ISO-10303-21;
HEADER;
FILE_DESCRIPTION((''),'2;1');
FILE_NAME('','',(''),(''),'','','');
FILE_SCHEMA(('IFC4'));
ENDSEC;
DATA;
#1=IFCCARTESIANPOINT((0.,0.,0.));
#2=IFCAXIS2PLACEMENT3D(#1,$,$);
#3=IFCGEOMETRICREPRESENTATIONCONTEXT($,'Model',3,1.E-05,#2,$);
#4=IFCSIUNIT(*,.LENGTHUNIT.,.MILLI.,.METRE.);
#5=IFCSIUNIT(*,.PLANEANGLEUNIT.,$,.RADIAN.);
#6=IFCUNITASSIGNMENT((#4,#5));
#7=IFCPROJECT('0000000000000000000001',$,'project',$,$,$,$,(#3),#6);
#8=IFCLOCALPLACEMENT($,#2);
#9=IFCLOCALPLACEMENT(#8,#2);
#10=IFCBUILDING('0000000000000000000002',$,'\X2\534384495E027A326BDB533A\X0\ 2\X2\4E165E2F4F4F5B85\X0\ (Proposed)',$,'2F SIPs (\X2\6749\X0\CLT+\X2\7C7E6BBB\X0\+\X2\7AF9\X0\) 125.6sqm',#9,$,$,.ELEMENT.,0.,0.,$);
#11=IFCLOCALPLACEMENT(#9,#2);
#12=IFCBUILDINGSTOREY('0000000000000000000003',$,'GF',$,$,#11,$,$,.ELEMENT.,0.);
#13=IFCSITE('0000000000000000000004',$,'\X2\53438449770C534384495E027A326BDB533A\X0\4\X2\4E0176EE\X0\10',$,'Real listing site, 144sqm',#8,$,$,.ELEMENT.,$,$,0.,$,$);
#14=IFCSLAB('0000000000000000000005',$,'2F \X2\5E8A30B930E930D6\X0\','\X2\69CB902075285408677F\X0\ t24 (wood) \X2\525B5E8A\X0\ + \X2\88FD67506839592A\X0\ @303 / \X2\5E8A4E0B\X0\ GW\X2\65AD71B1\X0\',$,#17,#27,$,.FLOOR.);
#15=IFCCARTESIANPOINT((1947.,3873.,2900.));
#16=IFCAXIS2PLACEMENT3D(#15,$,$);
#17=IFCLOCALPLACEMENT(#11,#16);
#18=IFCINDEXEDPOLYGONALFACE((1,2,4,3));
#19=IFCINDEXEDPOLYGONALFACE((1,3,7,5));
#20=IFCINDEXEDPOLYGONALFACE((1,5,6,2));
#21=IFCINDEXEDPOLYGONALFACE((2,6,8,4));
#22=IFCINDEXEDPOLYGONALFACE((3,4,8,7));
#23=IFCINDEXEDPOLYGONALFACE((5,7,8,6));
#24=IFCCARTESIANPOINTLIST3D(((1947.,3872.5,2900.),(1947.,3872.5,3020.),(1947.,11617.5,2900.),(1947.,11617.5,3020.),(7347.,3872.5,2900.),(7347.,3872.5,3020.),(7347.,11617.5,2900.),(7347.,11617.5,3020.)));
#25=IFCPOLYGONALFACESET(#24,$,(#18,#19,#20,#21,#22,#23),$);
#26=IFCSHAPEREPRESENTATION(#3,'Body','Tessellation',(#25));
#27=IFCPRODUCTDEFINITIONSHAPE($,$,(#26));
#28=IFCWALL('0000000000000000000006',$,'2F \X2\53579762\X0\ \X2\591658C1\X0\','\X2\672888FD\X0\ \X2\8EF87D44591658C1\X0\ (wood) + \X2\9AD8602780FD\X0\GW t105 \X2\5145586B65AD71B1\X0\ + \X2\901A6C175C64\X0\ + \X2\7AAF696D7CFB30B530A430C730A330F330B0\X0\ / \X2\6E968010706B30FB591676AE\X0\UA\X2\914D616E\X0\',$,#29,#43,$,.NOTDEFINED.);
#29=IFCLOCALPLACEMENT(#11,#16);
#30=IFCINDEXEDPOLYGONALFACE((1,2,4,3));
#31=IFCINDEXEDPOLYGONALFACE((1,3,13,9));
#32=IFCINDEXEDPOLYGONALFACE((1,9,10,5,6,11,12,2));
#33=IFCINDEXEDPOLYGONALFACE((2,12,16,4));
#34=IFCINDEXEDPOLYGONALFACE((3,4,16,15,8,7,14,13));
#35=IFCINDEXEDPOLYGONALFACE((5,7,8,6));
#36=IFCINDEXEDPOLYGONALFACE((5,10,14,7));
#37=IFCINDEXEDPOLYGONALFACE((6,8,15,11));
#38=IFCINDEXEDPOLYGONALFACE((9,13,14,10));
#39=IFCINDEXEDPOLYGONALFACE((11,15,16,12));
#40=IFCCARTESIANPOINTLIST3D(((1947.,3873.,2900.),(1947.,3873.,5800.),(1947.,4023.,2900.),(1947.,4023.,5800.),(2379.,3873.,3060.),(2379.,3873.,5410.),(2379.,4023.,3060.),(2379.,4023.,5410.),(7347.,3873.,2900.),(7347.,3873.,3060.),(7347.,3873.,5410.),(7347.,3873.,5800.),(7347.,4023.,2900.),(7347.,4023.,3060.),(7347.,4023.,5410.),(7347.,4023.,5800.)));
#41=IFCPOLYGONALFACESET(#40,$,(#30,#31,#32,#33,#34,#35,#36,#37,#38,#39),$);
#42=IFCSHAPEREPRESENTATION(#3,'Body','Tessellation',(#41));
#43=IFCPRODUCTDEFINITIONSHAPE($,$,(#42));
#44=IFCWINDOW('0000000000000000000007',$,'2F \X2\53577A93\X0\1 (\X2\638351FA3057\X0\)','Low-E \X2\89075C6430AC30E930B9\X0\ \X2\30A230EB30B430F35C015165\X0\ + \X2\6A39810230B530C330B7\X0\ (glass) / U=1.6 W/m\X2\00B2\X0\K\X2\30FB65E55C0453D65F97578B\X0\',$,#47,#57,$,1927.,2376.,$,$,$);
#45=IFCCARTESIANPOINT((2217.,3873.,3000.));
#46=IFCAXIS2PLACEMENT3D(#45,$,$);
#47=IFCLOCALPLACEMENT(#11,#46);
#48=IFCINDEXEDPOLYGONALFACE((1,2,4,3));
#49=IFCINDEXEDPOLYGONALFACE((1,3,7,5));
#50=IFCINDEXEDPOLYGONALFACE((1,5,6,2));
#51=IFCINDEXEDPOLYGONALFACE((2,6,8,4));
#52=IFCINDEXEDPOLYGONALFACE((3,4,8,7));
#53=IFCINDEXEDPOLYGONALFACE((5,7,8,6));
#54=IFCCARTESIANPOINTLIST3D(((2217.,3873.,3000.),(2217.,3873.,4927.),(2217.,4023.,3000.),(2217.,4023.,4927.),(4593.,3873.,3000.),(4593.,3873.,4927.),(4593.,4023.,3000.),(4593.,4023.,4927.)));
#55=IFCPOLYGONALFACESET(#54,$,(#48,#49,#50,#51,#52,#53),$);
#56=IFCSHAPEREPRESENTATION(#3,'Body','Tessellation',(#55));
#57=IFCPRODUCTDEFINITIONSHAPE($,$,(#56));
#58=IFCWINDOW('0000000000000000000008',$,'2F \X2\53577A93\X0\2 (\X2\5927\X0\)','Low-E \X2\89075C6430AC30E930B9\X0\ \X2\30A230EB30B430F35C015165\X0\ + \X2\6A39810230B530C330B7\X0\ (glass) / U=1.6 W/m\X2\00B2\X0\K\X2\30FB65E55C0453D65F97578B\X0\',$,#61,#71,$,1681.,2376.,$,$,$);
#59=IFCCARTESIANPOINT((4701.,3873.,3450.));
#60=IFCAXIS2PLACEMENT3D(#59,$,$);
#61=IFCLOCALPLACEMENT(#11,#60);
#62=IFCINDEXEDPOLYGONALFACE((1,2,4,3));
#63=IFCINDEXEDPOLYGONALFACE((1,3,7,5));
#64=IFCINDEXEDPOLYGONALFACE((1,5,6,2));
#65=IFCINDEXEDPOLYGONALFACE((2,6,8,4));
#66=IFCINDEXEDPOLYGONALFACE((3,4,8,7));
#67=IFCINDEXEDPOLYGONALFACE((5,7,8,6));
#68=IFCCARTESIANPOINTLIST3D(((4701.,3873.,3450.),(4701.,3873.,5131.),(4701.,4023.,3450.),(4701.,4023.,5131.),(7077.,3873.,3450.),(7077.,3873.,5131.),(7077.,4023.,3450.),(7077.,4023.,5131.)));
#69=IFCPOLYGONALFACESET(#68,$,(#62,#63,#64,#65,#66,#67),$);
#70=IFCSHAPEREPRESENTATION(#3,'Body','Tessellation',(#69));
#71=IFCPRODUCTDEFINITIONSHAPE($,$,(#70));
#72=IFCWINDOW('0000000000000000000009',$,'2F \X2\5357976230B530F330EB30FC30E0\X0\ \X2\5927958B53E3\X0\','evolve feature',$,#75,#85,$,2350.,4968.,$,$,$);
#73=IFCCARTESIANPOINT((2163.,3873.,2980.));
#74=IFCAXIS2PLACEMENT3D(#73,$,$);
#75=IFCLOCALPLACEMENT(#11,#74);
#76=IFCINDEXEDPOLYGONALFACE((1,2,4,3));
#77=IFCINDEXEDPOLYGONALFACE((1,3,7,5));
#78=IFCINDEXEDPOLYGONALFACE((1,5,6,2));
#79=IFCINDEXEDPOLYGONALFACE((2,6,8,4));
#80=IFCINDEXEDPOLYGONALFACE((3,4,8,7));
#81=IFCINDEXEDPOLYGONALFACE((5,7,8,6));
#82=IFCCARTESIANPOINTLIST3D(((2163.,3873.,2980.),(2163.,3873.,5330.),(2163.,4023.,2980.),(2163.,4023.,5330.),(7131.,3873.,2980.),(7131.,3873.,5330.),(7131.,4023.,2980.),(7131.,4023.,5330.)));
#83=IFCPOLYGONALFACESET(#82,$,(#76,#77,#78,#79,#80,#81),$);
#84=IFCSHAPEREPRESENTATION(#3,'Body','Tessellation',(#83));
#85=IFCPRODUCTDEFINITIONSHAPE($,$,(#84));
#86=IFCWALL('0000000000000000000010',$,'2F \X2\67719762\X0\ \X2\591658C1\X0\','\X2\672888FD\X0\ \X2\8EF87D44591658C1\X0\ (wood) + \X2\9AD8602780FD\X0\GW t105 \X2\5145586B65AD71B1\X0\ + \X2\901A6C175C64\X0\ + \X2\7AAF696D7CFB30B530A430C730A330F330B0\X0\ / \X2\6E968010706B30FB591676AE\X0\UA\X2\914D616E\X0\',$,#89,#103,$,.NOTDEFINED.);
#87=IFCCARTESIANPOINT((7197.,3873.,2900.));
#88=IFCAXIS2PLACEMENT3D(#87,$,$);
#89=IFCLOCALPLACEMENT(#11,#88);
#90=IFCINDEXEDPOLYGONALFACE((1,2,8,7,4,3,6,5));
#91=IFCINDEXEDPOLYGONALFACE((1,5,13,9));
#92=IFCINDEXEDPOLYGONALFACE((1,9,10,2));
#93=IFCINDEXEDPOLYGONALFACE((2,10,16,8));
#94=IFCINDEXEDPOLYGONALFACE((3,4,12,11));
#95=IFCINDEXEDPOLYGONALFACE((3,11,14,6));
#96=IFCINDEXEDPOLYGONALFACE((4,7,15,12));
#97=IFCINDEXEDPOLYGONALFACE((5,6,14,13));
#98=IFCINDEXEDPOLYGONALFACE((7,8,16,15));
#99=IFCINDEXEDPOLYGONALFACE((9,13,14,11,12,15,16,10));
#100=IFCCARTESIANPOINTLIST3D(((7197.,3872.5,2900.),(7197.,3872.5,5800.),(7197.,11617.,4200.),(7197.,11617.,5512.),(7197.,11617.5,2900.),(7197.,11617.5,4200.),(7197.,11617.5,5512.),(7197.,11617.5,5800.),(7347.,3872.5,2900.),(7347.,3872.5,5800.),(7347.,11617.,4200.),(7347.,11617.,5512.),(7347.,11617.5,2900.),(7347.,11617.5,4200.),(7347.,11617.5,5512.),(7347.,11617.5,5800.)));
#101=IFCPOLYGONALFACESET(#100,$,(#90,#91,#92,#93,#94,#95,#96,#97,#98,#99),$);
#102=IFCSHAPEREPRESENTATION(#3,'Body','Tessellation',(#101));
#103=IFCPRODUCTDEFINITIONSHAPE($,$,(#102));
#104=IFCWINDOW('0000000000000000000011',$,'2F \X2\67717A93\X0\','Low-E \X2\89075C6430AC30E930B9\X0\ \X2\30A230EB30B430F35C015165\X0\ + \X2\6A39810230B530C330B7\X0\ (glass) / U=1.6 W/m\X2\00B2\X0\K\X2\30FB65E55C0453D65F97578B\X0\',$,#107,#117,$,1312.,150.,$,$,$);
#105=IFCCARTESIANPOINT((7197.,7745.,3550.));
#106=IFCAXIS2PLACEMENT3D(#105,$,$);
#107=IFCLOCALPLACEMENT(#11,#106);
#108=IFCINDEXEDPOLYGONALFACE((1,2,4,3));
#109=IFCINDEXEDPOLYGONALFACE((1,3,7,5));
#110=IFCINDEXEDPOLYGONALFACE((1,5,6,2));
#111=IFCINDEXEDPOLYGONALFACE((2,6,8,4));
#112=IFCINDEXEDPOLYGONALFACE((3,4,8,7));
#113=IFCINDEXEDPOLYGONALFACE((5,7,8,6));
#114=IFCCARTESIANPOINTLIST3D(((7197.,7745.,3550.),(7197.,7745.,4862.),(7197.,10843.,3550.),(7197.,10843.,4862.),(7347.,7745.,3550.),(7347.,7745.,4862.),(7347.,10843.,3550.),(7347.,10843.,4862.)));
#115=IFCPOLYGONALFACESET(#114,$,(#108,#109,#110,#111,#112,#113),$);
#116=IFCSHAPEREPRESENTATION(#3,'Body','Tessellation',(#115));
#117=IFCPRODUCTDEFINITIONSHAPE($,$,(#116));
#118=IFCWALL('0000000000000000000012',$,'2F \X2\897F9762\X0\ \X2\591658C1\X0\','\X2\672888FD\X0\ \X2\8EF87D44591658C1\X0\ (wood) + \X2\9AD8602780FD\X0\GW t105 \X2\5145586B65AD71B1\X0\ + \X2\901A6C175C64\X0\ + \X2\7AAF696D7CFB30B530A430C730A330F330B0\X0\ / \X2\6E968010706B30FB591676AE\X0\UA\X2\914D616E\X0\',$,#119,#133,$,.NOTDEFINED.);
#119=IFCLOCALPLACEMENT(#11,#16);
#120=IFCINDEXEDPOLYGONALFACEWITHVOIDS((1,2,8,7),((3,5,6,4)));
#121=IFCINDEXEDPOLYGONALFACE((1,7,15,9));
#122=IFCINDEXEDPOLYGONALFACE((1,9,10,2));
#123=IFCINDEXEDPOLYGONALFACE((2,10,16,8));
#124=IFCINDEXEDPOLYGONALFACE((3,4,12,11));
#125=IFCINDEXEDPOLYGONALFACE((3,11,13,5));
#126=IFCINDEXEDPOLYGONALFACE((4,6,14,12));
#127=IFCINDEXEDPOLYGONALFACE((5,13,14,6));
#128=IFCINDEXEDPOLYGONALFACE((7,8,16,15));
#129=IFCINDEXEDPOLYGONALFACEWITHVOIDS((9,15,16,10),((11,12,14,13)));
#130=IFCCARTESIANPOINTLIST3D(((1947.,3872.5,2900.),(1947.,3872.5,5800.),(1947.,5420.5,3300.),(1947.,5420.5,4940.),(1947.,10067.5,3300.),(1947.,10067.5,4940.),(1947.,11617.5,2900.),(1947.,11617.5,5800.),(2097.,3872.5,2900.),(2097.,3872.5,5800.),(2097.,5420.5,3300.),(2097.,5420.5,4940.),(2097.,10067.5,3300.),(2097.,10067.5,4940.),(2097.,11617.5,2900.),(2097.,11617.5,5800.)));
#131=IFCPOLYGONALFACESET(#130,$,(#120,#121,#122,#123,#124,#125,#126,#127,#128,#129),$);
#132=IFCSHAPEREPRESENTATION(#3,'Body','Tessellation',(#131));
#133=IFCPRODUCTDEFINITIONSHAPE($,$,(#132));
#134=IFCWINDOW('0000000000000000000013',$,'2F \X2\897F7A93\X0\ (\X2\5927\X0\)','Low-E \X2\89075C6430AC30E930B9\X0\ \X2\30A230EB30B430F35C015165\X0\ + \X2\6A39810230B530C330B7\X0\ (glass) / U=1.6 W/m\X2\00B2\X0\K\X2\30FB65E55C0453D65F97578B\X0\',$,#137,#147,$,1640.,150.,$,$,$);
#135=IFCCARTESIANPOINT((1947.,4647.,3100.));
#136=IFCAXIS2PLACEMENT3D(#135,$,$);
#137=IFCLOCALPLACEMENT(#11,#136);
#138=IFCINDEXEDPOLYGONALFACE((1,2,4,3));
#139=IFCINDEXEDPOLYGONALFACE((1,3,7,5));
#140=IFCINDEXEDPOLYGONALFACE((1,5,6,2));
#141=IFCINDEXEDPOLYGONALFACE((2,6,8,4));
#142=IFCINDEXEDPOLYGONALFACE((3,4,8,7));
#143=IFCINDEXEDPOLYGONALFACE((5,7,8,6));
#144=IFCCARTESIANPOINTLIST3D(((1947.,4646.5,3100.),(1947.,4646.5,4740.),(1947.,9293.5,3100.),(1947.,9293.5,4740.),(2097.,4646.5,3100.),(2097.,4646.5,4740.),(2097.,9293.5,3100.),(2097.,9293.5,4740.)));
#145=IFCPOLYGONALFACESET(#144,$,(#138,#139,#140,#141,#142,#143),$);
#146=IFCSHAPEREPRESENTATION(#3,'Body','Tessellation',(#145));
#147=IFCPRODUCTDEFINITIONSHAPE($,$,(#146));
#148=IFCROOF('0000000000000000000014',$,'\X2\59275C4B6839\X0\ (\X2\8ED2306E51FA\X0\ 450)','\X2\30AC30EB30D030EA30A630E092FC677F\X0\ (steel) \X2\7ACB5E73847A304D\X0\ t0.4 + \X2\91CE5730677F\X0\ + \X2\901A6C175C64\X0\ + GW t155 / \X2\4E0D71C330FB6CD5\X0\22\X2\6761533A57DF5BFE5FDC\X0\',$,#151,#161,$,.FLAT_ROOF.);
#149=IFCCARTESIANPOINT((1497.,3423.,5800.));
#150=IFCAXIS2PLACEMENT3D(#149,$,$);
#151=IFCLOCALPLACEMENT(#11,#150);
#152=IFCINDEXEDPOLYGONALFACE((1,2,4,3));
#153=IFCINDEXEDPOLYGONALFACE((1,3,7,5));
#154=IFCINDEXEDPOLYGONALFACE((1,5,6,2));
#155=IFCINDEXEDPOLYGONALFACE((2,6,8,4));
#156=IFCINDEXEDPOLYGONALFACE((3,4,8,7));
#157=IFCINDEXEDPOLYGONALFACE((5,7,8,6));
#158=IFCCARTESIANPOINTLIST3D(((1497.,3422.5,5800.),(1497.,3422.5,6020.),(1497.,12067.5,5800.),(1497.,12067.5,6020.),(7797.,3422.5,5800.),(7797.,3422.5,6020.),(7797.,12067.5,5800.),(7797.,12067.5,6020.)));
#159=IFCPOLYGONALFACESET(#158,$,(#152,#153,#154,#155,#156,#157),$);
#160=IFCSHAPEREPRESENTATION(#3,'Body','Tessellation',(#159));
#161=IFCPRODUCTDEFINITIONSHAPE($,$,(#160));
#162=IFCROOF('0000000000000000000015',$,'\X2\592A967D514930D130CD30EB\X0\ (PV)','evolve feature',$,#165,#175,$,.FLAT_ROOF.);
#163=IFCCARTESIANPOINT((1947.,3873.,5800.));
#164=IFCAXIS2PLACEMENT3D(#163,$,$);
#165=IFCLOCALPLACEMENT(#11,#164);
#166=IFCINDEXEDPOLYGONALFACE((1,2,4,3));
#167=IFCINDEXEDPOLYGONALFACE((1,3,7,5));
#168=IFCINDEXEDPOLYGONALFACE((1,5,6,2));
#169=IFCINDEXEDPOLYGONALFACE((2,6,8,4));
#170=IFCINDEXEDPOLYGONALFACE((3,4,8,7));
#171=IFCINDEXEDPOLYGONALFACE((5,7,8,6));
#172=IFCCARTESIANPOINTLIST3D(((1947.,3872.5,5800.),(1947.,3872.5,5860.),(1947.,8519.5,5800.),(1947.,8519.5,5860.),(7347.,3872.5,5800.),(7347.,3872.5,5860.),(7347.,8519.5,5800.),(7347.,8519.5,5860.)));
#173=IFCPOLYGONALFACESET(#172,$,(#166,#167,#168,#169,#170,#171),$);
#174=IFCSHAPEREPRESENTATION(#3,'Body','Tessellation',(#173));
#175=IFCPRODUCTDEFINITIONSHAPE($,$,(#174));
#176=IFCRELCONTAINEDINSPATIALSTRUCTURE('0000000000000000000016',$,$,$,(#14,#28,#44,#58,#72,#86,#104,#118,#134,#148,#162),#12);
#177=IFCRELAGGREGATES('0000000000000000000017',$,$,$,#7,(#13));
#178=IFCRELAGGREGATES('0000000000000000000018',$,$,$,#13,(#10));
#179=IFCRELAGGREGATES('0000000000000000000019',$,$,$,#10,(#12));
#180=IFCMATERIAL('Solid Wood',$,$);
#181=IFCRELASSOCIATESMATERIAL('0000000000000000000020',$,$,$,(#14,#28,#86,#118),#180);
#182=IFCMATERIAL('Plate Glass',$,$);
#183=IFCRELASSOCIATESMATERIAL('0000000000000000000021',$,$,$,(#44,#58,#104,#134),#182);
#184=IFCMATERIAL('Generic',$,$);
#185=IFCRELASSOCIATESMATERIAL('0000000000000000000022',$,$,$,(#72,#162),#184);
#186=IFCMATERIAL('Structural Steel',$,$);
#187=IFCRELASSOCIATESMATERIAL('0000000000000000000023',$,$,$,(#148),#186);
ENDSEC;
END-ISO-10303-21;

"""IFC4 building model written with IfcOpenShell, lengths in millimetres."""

from ifc_helpers import new_model, si_unit, frame, frame_2d, origin, place, context, project, spatial, rectangle, extrude, material, element, fill, save


model = new_model("IFC4")

# Units and contexts
model_context = context("Model", 3, precision=1e-05, world=origin())
ifc_project = project(units=[si_unit("LENGTHUNIT", "METRE", prefix="MILLI"), si_unit("PLANEANGLEUNIT", "RADIAN")], contexts=[model_context])

# Site, building, storey
site_placement = place(None, origin())
site = spatial("IfcSite", under=ifc_project, at=site_placement, Name="千葉県千葉市稲毛区4丁目10", ObjectType="Real listing site, 144sqm", CompositionType="ELEMENT", RefElevation=0.0)
building_placement = place(site_placement, origin())
building = spatial("IfcBuilding", under=site, at=building_placement, Name="千葉市稲毛区 2世帯住宅 (Proposed)", ObjectType="2F SIPs (杉CLT+籾殻+竹) 125.6sqm", CompositionType="ELEMENT", ElevationOfRefHeight=0.0, ElevationOfTerrain=0.0)
storey_placement = place(building_placement, origin())
storey = spatial("IfcBuildingStorey", under=building, at=storey_placement, Name="GF", CompositionType="ELEMENT", Elevation=0.0)

# Slab
ifc_material_1 = material(Name="Solid Wood")
slab_placement = place(storey_placement, frame((1947.0, 3873.0, 2900.0)))
element("IfcSlab", 1, at=slab_placement, inside=storey, material=ifc_material_1, Name="2F 床スラブ", Description="構造用合板 t24 (wood) 剛床 + 製材根太 @303 / 床下 GW断熱", PredefinedType="FLOOR", context=model_context, shape_type="SweptSolid", body=[
    extrude(rectangle(XDim=5400.0, YDim=7745.0, at=frame_2d((2700.0, 3872.0))), frame((1947.0, 3873.0, 2900.0)), (0.0, 0.0, 1.0), 120.0),
])

# Wall, openings, windows
wall_1_placement = place(storey_placement, frame((1947.0, 3873.0, 2900.0)))
wall_1 = element("IfcWall", 2, at=wall_1_placement, inside=storey, material=ifc_material_1, Name="2F 南面 外壁", Description="木製 軸組外壁 (wood) + 高性能GW t105 充填断熱 + 通気層 + 窯業系サイディング / 準耐火・外皮UA配慮", PredefinedType="NOTDEFINED", context=model_context, shape_type="SweptSolid", body=[
    extrude(rectangle(XDim=5400.0, YDim=150.0, at=frame_2d((2700.0, 75.0))), frame((1947.0, 3873.0, 2900.0)), (0.0, 0.0, 1.0), 2900.0),
])
opening_1_placement = place(storey_placement, frame((2217.0, 3873.0, 3000.0)))
opening_1 = element("IfcOpeningElement", 3, at=opening_1_placement, cuts=wall_1, PredefinedType="NOTDEFINED", context=model_context, shape_type="SweptSolid", body=[
    extrude(rectangle(XDim=2376.0, YDim=150.0, at=frame_2d((1188.0, 75.0))), frame((2217.0, 3873.0, 3000.0)), (0.0, 0.0, 1.0), 1927.0),
])
opening_2_placement = place(storey_placement, frame((4701.0, 3873.0, 3450.0)))
opening_2 = element("IfcOpeningElement", 4, at=opening_2_placement, cuts=wall_1, PredefinedType="NOTDEFINED", context=model_context, shape_type="SweptSolid", body=[
    extrude(rectangle(XDim=2376.0, YDim=150.0, at=frame_2d((1188.0, 75.0))), frame((4701.0, 3873.0, 3450.0)), (0.0, 0.0, 1.0), 1681.0),
])
opening_3_placement = place(storey_placement, frame((2163.0, 3873.0, 2980.0)))
opening_3 = element("IfcOpeningElement", 5, at=opening_3_placement, cuts=wall_1, PredefinedType="NOTDEFINED", context=model_context, shape_type="SweptSolid", body=[
    extrude(rectangle(XDim=4968.0, YDim=150.0, at=frame_2d((2484.0, 75.0))), frame((2163.0, 3873.0, 2980.0)), (0.0, 0.0, 1.0), 2350.0),
])
ifc_material_2 = material(Name="Plate Glass")
window_1_placement = place(storey_placement, frame((2217.0, 3873.0, 3000.0)))
window_1 = element("IfcWindow", 6, at=window_1_placement, inside=storey, material=ifc_material_2, Name="2F 南窓1 (掃出し)", Description="Low-E 複層ガラス アルゴン封入 + 樹脂サッシ (glass) / U=1.6 W/m²K・日射取得型", OverallHeight=1927.0, OverallWidth=2376.0, context=model_context, shape_type="SweptSolid", body=[
    extrude(rectangle(XDim=2376.0, YDim=150.0, at=frame_2d((1188.0, 75.0))), frame((2217.0, 3873.0, 3000.0)), (0.0, 0.0, 1.0), 1927.0),
])
fill(opening_1, window_1)
window_2_placement = place(storey_placement, frame((4701.0, 3873.0, 3450.0)))
window_2 = element("IfcWindow", 7, at=window_2_placement, inside=storey, material=ifc_material_2, Name="2F 南窓2 (大)", Description="Low-E 複層ガラス アルゴン封入 + 樹脂サッシ (glass) / U=1.6 W/m²K・日射取得型", OverallHeight=1681.0, OverallWidth=2376.0, context=model_context, shape_type="SweptSolid", body=[
    extrude(rectangle(XDim=2376.0, YDim=150.0, at=frame_2d((1188.0, 75.0))), frame((4701.0, 3873.0, 3450.0)), (0.0, 0.0, 1.0), 1681.0),
])
fill(opening_2, window_2)
ifc_material_3 = material(Name="Generic")
window_3_placement = place(storey_placement, frame((2163.0, 3873.0, 2980.0)))
window_3 = element("IfcWindow", 8, at=window_3_placement, inside=storey, material=ifc_material_3, Name="2F 南面サンルーム 大開口", Description="evolve feature", OverallHeight=2350.0, OverallWidth=4968.0, context=model_context, shape_type="SweptSolid", body=[
    extrude(rectangle(XDim=4968.0, YDim=150.0, at=frame_2d((2484.0, 75.0))), frame((2163.0, 3873.0, 2980.0)), (0.0, 0.0, 1.0), 2350.0),
])
fill(opening_3, window_3)

# Walls, openings, windows
wall_2_placement = place(storey_placement, frame((7197.0, 3873.0, 2900.0)))
wall_2 = element("IfcWall", 9, at=wall_2_placement, inside=storey, material=ifc_material_1, Name="2F 東面 外壁", Description="木製 軸組外壁 (wood) + 高性能GW t105 充填断熱 + 通気層 + 窯業系サイディング / 準耐火・外皮UA配慮", PredefinedType="NOTDEFINED", context=model_context, shape_type="SweptSolid", body=[
    extrude(rectangle(XDim=150.0, YDim=7745.0, at=frame_2d((75.0, 3872.0))), frame((7197.0, 3873.0, 2900.0)), (0.0, 0.0, 1.0), 2900.0),
])
opening_4_placement = place(storey_placement, frame((7197.0, 7745.0, 3550.0)))
opening_4 = element("IfcOpeningElement", 10, at=opening_4_placement, cuts=wall_2, PredefinedType="NOTDEFINED", context=model_context, shape_type="SweptSolid", body=[
    extrude(rectangle(XDim=150.0, YDim=3098.0, at=frame_2d((75.0, 1549.0))), frame((7197.0, 7745.0, 3550.0)), (0.0, 0.0, 1.0), 1312.0),
])
window_4_placement = place(storey_placement, frame((7197.0, 7745.0, 3550.0)))
window_4 = element("IfcWindow", 11, at=window_4_placement, inside=storey, material=ifc_material_2, Name="2F 東窓", Description="Low-E 複層ガラス アルゴン封入 + 樹脂サッシ (glass) / U=1.6 W/m²K・日射取得型", OverallHeight=1312.0, OverallWidth=150.0, context=model_context, shape_type="SweptSolid", body=[
    extrude(rectangle(XDim=150.0, YDim=3098.0, at=frame_2d((75.0, 1549.0))), frame((7197.0, 7745.0, 3550.0)), (0.0, 0.0, 1.0), 1312.0),
])
fill(opening_4, window_4)
wall_3_placement = place(storey_placement, frame((1947.0, 3873.0, 2900.0)))
wall_3 = element("IfcWall", 12, at=wall_3_placement, inside=storey, material=ifc_material_1, Name="2F 西面 外壁", Description="木製 軸組外壁 (wood) + 高性能GW t105 充填断熱 + 通気層 + 窯業系サイディング / 準耐火・外皮UA配慮", PredefinedType="NOTDEFINED", context=model_context, shape_type="SweptSolid", body=[
    extrude(rectangle(XDim=150.0, YDim=7745.0, at=frame_2d((75.0, 3872.0))), frame((1947.0, 3873.0, 2900.0)), (0.0, 0.0, 1.0), 2900.0),
])
opening_5_placement = place(storey_placement, frame((1947.0, 4647.0, 3100.0)))
opening_5 = element("IfcOpeningElement", 13, at=opening_5_placement, cuts=wall_3, PredefinedType="NOTDEFINED", context=model_context, shape_type="SweptSolid", body=[
    extrude(rectangle(XDim=150.0, YDim=4647.0, at=frame_2d((75.0, 2323.0))), frame((1947.0, 4647.0, 3100.0)), (0.0, 0.0, 1.0), 1640.0),
])
window_5_placement = place(storey_placement, frame((1947.0, 4647.0, 3100.0)))
window_5 = element("IfcWindow", 14, at=window_5_placement, inside=storey, material=ifc_material_2, Name="2F 西窓 (大)", Description="Low-E 複層ガラス アルゴン封入 + 樹脂サッシ (glass) / U=1.6 W/m²K・日射取得型", OverallHeight=1640.0, OverallWidth=150.0, context=model_context, shape_type="SweptSolid", body=[
    extrude(rectangle(XDim=150.0, YDim=4647.0, at=frame_2d((75.0, 2323.0))), frame((1947.0, 4647.0, 3100.0)), (0.0, 0.0, 1.0), 1640.0),
])
fill(opening_5, window_5)

# Roofs
ifc_material_4 = material(Name="Structural Steel")
roof_1_placement = place(storey_placement, frame((1497.0, 3423.0, 5800.0)))
element("IfcRoof", 15, at=roof_1_placement, inside=storey, material=ifc_material_4, Name="大屋根 (軒の出 450)", Description="ガルバリウム鋼板 (steel) 立平葺き t0.4 + 野地板 + 通気層 + GW t155 / 不燃・法22条区域対応", PredefinedType="FLAT_ROOF", context=model_context, shape_type="SweptSolid", body=[
    extrude(rectangle(XDim=6300.0, YDim=8645.0, at=frame_2d((3150.0, 4322.0))), frame((1497.0, 3423.0, 5800.0)), (0.0, 0.0, 1.0), 220.0),
])
roof_2_placement = place(storey_placement, frame((1947.0, 3873.0, 5800.0)))
element("IfcRoof", 16, at=roof_2_placement, inside=storey, material=ifc_material_3, Name="太陽光パネル (PV)", Description="evolve feature", PredefinedType="FLAT_ROOF", context=model_context, shape_type="SweptSolid", body=[
    extrude(rectangle(XDim=5400.0, YDim=4647.0, at=frame_2d((2700.0, 2323.0))), frame((1947.0, 3873.0, 5800.0)), (0.0, 0.0, 1.0), 60.0),
])

save(model, "model.ifc")
